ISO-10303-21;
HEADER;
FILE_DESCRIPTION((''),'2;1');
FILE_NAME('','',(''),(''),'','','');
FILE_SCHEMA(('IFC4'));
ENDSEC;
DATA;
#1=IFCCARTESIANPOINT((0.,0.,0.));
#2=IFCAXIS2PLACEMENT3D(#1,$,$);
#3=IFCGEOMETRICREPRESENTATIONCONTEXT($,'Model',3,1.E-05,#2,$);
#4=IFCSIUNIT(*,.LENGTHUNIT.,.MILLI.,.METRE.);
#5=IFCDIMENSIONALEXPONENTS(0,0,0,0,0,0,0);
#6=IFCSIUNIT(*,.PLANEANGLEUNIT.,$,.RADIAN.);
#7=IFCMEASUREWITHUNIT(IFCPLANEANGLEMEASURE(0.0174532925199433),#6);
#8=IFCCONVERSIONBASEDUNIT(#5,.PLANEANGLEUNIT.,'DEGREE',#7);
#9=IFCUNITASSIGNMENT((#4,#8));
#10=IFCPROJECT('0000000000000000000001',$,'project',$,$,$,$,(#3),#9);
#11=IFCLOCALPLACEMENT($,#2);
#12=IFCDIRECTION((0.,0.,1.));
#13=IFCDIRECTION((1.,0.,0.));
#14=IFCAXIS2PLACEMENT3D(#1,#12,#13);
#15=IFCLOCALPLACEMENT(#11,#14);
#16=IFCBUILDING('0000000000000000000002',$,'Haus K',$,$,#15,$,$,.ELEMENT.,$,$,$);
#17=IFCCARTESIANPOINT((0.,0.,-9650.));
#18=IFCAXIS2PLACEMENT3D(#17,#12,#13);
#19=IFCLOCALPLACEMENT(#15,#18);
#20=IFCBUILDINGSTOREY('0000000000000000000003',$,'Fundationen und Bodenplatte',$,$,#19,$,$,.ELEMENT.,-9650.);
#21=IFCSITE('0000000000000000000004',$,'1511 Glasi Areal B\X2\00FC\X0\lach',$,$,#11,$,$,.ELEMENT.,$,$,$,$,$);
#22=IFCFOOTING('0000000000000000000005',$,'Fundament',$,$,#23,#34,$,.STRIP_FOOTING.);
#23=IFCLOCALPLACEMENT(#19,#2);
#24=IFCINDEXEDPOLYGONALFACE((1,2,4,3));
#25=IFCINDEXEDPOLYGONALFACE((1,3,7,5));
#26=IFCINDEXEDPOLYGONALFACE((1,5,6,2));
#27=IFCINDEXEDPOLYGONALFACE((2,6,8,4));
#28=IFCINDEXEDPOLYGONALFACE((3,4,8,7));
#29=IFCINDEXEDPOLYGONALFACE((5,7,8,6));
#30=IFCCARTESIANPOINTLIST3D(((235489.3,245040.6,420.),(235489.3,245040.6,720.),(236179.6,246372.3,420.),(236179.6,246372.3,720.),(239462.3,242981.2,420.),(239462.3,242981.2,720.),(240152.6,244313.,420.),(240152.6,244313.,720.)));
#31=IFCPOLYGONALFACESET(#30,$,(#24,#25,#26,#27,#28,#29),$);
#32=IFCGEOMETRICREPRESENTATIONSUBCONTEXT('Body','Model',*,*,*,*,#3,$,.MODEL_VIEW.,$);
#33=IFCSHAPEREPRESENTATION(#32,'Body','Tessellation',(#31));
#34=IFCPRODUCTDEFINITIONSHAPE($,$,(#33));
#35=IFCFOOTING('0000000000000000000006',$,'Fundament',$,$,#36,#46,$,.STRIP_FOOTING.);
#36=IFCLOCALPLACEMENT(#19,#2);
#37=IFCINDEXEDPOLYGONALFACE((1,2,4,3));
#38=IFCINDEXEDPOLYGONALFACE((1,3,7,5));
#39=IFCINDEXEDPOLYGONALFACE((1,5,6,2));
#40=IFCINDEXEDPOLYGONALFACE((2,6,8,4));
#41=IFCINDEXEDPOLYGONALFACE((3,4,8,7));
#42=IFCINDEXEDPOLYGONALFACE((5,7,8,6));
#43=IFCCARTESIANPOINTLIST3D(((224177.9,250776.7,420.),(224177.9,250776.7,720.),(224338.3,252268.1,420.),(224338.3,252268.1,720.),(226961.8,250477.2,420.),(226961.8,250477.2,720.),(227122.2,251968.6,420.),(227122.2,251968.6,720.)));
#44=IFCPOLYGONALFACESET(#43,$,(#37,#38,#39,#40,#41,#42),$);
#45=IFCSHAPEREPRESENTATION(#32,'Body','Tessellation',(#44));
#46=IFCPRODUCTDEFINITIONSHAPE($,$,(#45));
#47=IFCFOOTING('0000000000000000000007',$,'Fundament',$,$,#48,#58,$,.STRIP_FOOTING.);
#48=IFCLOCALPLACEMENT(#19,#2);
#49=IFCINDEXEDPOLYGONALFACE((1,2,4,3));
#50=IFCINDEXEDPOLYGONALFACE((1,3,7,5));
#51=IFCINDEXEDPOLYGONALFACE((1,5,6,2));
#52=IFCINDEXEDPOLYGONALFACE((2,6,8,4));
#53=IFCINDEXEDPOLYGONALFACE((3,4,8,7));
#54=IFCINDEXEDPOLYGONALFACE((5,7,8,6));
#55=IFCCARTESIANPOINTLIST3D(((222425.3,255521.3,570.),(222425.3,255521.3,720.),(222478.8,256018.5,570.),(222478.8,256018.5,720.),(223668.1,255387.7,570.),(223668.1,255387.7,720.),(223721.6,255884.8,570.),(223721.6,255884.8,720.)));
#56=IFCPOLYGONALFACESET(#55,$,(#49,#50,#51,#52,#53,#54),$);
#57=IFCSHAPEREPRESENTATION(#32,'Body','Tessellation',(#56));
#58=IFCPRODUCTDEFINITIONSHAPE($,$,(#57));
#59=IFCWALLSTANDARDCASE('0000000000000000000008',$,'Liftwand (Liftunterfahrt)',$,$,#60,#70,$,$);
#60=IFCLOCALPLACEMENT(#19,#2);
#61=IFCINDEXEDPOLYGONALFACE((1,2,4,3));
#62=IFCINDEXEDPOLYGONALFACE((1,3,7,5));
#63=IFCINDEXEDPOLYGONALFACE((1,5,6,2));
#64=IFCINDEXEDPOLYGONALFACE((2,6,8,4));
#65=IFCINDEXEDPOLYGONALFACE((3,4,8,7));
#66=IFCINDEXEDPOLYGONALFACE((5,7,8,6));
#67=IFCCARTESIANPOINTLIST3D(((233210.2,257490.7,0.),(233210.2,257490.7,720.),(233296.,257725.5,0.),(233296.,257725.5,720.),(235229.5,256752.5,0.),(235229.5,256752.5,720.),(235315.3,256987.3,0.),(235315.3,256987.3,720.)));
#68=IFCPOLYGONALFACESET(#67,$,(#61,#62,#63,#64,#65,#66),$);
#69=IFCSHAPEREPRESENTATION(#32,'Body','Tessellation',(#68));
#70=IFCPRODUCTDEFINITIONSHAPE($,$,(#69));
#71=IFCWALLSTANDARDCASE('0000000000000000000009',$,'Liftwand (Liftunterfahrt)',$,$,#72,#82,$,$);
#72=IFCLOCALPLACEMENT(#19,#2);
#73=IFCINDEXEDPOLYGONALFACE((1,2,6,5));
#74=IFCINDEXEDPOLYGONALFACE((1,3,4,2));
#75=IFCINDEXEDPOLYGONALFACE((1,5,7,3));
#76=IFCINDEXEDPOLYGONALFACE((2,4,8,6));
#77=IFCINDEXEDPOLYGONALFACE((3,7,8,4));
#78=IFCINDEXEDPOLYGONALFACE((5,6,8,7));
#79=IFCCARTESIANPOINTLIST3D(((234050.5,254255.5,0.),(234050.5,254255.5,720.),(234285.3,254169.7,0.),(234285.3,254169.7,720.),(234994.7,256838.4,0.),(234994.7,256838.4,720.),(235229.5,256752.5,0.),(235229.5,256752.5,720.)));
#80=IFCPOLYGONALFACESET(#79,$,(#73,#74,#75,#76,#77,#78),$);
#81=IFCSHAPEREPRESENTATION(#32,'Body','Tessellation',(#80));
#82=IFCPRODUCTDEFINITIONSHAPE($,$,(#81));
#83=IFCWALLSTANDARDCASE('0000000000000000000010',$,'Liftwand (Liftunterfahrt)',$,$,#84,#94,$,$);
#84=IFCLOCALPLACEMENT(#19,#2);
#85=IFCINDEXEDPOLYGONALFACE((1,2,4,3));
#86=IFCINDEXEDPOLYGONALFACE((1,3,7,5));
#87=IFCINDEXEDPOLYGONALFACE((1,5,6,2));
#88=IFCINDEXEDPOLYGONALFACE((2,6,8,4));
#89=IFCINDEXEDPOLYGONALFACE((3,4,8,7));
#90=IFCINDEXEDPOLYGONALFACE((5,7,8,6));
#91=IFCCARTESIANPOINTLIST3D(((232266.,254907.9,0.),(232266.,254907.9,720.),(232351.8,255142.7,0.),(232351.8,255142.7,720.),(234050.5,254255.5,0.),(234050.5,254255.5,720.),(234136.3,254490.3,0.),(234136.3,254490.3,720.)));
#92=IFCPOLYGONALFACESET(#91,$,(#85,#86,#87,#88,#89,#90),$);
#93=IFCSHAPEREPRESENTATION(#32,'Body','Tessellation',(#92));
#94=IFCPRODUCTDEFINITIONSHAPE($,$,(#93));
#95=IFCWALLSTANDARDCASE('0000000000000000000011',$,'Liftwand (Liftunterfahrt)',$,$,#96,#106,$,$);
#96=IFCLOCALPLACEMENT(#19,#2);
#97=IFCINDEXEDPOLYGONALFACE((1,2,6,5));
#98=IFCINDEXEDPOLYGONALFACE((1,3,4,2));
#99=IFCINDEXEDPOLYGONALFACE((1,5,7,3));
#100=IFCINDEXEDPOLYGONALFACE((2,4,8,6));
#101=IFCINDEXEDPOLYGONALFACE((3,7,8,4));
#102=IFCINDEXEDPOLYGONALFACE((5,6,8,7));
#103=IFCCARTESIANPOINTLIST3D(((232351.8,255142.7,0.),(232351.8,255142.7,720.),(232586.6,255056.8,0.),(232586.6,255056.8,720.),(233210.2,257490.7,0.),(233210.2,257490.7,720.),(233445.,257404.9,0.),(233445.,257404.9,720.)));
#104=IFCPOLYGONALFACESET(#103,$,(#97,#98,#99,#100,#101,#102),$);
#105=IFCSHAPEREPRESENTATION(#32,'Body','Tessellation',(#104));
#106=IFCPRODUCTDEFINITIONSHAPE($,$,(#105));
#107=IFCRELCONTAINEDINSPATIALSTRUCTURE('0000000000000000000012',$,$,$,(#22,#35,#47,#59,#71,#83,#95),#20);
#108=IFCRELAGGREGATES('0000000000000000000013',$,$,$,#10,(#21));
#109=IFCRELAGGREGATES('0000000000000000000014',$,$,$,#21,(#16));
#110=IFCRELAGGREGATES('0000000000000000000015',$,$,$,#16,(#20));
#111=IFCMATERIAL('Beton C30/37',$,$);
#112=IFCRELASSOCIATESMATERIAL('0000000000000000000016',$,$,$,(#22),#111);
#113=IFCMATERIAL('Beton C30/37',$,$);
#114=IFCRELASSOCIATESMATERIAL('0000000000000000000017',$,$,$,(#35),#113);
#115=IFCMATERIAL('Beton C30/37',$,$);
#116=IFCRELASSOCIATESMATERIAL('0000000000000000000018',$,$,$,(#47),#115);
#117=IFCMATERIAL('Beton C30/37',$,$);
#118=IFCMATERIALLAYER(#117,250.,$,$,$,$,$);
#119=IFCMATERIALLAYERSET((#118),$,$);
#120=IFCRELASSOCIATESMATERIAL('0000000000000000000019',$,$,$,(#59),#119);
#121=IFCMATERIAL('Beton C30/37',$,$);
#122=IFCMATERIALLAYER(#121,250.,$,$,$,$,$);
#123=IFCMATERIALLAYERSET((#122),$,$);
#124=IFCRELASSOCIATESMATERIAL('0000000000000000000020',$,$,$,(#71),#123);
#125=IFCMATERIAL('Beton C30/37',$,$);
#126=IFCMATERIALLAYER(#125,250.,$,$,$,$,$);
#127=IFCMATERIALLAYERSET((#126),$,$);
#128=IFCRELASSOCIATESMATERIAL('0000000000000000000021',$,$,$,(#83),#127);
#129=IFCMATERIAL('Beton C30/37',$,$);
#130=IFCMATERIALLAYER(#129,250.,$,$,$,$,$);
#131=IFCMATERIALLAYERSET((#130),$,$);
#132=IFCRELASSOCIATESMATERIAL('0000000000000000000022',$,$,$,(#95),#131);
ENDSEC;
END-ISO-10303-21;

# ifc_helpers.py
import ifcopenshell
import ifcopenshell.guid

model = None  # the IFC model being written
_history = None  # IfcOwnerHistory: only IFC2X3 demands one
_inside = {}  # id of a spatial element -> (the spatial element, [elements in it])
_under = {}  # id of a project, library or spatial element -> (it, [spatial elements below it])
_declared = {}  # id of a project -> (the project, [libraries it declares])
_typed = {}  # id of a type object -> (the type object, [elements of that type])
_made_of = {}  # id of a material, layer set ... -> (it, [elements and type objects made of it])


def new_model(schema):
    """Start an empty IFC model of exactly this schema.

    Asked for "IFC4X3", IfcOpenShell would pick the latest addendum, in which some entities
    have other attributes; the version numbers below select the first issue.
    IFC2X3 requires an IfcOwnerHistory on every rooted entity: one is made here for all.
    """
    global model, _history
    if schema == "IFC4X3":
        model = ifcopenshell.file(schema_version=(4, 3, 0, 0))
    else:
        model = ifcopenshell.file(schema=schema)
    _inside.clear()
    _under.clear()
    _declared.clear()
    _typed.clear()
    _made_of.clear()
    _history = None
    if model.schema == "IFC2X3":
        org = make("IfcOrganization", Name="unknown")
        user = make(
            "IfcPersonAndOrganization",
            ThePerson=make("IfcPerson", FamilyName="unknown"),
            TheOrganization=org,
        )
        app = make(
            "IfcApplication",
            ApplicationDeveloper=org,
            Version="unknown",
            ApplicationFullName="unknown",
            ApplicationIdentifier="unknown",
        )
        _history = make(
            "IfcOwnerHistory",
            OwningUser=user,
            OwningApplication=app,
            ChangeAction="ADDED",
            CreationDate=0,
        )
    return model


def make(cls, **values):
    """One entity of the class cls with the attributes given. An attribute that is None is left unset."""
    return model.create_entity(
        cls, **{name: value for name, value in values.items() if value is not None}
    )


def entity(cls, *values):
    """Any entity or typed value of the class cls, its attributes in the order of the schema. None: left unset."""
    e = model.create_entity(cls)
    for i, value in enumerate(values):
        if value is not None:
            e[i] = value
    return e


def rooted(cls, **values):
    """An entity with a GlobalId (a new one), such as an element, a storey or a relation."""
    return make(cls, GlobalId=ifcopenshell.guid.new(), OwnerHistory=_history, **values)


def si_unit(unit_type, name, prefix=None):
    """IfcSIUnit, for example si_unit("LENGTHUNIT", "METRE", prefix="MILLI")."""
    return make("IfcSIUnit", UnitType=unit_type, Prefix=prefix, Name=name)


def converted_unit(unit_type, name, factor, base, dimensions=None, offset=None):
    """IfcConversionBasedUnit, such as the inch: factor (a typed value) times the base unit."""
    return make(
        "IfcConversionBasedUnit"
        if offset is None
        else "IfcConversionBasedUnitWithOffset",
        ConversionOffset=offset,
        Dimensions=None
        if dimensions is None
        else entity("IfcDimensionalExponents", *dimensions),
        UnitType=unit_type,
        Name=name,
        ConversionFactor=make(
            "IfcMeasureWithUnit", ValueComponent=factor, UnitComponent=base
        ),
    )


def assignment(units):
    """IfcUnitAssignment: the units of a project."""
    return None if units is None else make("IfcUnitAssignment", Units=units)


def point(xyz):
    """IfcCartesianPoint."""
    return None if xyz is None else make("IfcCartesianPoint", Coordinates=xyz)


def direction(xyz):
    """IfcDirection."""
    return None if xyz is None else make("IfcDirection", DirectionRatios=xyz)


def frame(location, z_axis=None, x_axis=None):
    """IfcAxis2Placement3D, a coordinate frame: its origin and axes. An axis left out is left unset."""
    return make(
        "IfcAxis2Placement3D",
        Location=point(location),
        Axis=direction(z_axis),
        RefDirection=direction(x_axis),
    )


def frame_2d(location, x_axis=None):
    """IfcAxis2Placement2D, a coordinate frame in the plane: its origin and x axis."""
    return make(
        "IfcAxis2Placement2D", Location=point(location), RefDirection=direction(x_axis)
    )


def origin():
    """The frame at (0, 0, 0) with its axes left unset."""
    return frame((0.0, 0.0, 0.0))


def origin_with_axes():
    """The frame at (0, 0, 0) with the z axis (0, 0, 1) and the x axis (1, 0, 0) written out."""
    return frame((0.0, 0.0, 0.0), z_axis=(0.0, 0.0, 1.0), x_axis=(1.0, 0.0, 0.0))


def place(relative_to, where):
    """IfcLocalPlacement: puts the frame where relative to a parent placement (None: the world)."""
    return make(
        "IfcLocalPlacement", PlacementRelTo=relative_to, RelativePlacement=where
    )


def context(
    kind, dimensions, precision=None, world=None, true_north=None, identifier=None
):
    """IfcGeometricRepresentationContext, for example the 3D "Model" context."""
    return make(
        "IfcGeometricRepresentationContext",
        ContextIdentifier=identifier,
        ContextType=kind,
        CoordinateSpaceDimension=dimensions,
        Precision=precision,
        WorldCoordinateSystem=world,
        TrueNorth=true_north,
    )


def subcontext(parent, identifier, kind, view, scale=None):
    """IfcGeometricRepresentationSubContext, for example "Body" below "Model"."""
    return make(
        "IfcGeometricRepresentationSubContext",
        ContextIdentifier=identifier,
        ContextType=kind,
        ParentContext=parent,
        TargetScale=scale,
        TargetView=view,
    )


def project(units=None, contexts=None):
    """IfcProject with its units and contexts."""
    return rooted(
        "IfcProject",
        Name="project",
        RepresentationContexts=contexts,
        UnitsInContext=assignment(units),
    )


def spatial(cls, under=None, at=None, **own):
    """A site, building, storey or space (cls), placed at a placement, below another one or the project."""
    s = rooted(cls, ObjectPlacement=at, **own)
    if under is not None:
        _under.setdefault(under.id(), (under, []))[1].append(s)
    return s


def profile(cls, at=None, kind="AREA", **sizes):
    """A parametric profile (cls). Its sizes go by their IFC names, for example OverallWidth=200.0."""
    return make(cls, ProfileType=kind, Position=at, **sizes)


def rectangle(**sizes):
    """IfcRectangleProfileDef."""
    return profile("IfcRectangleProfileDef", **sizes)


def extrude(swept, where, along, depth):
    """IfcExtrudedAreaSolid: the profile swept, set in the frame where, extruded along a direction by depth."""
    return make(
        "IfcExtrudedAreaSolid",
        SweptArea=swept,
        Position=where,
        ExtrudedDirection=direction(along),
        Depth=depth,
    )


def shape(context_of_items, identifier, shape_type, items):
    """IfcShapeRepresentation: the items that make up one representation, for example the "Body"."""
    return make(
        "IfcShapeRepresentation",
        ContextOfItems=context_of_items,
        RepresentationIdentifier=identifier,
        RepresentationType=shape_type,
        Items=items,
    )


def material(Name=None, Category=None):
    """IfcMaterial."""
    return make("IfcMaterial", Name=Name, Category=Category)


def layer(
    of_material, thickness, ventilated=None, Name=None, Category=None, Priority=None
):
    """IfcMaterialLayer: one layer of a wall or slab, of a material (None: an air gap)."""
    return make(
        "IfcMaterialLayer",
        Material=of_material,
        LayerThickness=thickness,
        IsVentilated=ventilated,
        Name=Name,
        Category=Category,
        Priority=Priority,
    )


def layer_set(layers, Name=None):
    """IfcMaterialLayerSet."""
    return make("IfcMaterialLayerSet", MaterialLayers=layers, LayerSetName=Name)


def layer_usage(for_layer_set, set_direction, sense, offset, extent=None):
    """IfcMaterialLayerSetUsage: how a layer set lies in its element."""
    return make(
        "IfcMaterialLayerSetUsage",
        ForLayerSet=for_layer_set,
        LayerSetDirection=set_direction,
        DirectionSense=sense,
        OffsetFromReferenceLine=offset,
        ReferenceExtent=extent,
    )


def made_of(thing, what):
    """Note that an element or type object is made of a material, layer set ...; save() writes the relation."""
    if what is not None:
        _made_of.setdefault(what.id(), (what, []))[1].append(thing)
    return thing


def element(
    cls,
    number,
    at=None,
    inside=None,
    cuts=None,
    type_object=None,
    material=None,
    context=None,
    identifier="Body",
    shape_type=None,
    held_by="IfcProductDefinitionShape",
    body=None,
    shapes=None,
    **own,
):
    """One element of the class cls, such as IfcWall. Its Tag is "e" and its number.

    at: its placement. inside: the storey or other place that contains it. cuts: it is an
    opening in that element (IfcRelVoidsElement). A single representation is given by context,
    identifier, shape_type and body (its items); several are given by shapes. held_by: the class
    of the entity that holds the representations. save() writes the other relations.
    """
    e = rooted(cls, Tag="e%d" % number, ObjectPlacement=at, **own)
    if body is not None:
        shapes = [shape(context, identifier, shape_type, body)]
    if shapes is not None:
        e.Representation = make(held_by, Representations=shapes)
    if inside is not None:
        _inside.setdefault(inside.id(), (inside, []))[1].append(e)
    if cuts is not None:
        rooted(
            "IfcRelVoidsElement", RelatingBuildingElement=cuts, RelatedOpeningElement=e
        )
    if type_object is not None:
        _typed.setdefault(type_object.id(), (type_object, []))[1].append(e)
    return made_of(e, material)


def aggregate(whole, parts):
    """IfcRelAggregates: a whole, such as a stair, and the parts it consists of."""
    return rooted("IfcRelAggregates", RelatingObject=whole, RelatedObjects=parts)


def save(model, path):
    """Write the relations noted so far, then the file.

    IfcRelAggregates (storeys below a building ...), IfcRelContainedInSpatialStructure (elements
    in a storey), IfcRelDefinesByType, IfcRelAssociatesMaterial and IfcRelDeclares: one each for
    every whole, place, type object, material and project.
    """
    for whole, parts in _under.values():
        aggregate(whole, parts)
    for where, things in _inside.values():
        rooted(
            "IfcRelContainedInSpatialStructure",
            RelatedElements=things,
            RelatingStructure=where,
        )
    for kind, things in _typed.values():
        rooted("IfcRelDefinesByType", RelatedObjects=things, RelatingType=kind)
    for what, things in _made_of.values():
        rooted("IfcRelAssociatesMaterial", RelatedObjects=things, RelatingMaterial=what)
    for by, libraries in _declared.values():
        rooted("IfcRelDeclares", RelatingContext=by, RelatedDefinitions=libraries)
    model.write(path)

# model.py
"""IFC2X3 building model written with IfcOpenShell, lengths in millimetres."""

from ifc_helpers import new_model, entity, si_unit, converted_unit, frame, frame_2d, origin, origin_with_axes, place, context, subcontext, project, spatial, rectangle, extrude, material, layer, layer_set, layer_usage, element, save


model = new_model("IFC2X3")

# Units and contexts
model_context = context("Model", 3, precision=1e-05, world=origin())
body_context = subcontext(model_context, "Body", "Model", "MODEL_VIEW")
ifc_project = project(units=[si_unit("LENGTHUNIT", "METRE", prefix="MILLI"), converted_unit("PLANEANGLEUNIT", "DEGREE", entity("IfcPlaneAngleMeasure", 0.0174532925199433), si_unit("PLANEANGLEUNIT", "RADIAN"), dimensions=[0, 0, 0, 0, 0, 0, 0])], contexts=[model_context])

# Site, building, storey
site_placement = place(None, origin())
site = spatial("IfcSite", under=ifc_project, at=site_placement, Name="1511 Glasi Areal Bülach", CompositionType="ELEMENT")
building_placement = place(site_placement, origin_with_axes())
building = spatial("IfcBuilding", under=site, at=building_placement, Name="Haus K", CompositionType="ELEMENT")
storey_placement = place(building_placement, frame((0.0, 0.0, -9650.0), z_axis=(0.0, 0.0, 1.0), x_axis=(1.0, 0.0, 0.0)))
storey = spatial("IfcBuildingStorey", under=building, at=storey_placement, Name="Fundationen und Bodenplatte", CompositionType="ELEMENT", Elevation=-9650.0)

# Footings
ifc_material_1 = material(Name="Beton C30/37")
footing_1_placement = place(storey_placement, frame((235489.3, 245040.6, 420.0), z_axis=(0.0, 0.0, 1.0), x_axis=(0.887815, -0.4602, 0.0)))
element("IfcFooting", 1, at=footing_1_placement, inside=storey, material=ifc_material_1, Name="Fundament", PredefinedType="STRIP_FOOTING", context=body_context, shape_type="SweptSolid", body=[
    extrude(rectangle(XDim=300.0, YDim=1500.0, at=frame_2d((150.0, -750.0), x_axis=(1.0, 0.0))), frame((0.0, 0.0, 0.0), z_axis=(1.0, 0.0, 0.0), x_axis=(0.0, 0.0, 1.0)), (0.0, 0.0, 1.0), 4475.0),
])
ifc_material_2 = material(Name="Beton C30/37")
footing_2_placement = place(storey_placement, frame((224177.9, 250776.7, 420.0), z_axis=(0.0, 0.0, 1.0), x_axis=(0.994264, -0.106958, 0.0)))
element("IfcFooting", 2, at=footing_2_placement, inside=storey, material=ifc_material_2, Name="Fundament", PredefinedType="STRIP_FOOTING", context=body_context, shape_type="SweptSolid", body=[
    extrude(rectangle(XDim=300.0, YDim=1500.0, at=frame_2d((150.0, -750.0), x_axis=(1.0, 0.0))), frame((0.0, 0.0, 0.0), z_axis=(1.0, 0.0, 0.0), x_axis=(0.0, 0.0, 1.0)), (0.0, 0.0, 1.0), 2800.0),
])
ifc_material_3 = material(Name="Beton C30/37")
footing_3_placement = place(storey_placement, frame((223721.6, 255884.8, 570.0), z_axis=(0.0, 0.0, 1.0), x_axis=(-0.994264, 0.106958, 0.0)))
element("IfcFooting", 3, at=footing_3_placement, inside=storey, material=ifc_material_3, Name="Fundament", PredefinedType="STRIP_FOOTING", context=body_context, shape_type="SweptSolid", body=[
    extrude(rectangle(XDim=150.0, YDim=500.0, at=frame_2d((75.0, -250.0), x_axis=(1.0, 0.0))), frame((0.0, 0.0, 0.0), z_axis=(1.0, 0.0, 0.0), x_axis=(0.0, 0.0, 1.0)), (0.0, 0.0, 1.0), 1250.0),
])

# Walls
ifc_material_4 = material(Name="Beton C30/37")
ifc_layer_1 = layer(ifc_material_4, 250.0)
ifc_layer_set_1 = layer_set([ifc_layer_1])
ifc_layer_usage_1 = layer_usage(ifc_layer_set_1, "AXIS2", "POSITIVE", 0.0)
wall_1_placement = place(storey_placement, frame((235315.3, 256987.3, 0.0), z_axis=(0.0, 0.0, 1.0), x_axis=(-0.939214, 0.343332, 0.0)))
element("IfcWallStandardCase", 4, at=wall_1_placement, inside=storey, material=ifc_layer_usage_1, Name="Liftwand (Liftunterfahrt)", context=body_context, shape_type="SweptSolid", body=[
    extrude(rectangle(XDim=2150.0, YDim=250.0, at=frame_2d((1075.0, 125.0), x_axis=(1.0, 0.0))), origin_with_axes(), (0.0, 0.0, 1.0), 720.0),
])
ifc_material_5 = material(Name="Beton C30/37")
ifc_layer_2 = layer(ifc_material_5, 250.0)
ifc_layer_set_2 = layer_set([ifc_layer_2])
ifc_layer_usage_2 = layer_usage(ifc_layer_set_2, "AXIS2", "POSITIVE", 0.0)
wall_2_placement = place(storey_placement, frame((234285.3, 254169.7, 0.0), z_axis=(0.0, 0.0, 1.0), x_axis=(0.343332, 0.939214, 0.0)))
element("IfcWallStandardCase", 5, at=wall_2_placement, inside=storey, material=ifc_layer_usage_2, Name="Liftwand (Liftunterfahrt)", context=body_context, shape_type="SweptSolid", body=[
    extrude(rectangle(XDim=2750.0, YDim=250.0, at=frame_2d((1375.0, 125.0), x_axis=(1.0, 0.0))), origin_with_axes(), (0.0, 0.0, 1.0), 720.0),
])
ifc_material_6 = material(Name="Beton C30/37")
ifc_layer_3 = layer(ifc_material_6, 250.0)
ifc_layer_set_3 = layer_set([ifc_layer_3])
ifc_layer_usage_3 = layer_usage(ifc_layer_set_3, "AXIS2", "POSITIVE", 0.0)
wall_3_placement = place(storey_placement, frame((232266.0, 254907.9, 0.0), z_axis=(0.0, 0.0, 1.0), x_axis=(0.939214, -0.343332, 0.0)))
element("IfcWallStandardCase", 6, at=wall_3_placement, inside=storey, material=ifc_layer_usage_3, Name="Liftwand (Liftunterfahrt)", context=body_context, shape_type="SweptSolid", body=[
    extrude(rectangle(XDim=1900.0, YDim=250.0, at=frame_2d((950.0, 125.0), x_axis=(1.0, 0.0))), origin_with_axes(), (0.0, 0.0, 1.0), 720.0),
])
ifc_material_7 = material(Name="Beton C30/37")
ifc_layer_4 = layer(ifc_material_7, 250.0)
ifc_layer_set_4 = layer_set([ifc_layer_4])
ifc_layer_usage_4 = layer_usage(ifc_layer_set_4, "AXIS2", "POSITIVE", 0.0)
wall_4_placement = place(storey_placement, frame((233210.2, 257490.7, 0.0), z_axis=(0.0, 0.0, 1.0), x_axis=(-0.343332, -0.939214, 0.0)))
element("IfcWallStandardCase", 7, at=wall_4_placement, inside=storey, material=ifc_layer_usage_4, Name="Liftwand (Liftunterfahrt)", context=body_context, shape_type="SweptSolid", body=[
    extrude(rectangle(XDim=2500.0, YDim=250.0, at=frame_2d((1250.0, 125.0), x_axis=(1.0, 0.0))), origin_with_axes(), (0.0, 0.0, 1.0), 720.0),
])

save(model, "model.ifc")
